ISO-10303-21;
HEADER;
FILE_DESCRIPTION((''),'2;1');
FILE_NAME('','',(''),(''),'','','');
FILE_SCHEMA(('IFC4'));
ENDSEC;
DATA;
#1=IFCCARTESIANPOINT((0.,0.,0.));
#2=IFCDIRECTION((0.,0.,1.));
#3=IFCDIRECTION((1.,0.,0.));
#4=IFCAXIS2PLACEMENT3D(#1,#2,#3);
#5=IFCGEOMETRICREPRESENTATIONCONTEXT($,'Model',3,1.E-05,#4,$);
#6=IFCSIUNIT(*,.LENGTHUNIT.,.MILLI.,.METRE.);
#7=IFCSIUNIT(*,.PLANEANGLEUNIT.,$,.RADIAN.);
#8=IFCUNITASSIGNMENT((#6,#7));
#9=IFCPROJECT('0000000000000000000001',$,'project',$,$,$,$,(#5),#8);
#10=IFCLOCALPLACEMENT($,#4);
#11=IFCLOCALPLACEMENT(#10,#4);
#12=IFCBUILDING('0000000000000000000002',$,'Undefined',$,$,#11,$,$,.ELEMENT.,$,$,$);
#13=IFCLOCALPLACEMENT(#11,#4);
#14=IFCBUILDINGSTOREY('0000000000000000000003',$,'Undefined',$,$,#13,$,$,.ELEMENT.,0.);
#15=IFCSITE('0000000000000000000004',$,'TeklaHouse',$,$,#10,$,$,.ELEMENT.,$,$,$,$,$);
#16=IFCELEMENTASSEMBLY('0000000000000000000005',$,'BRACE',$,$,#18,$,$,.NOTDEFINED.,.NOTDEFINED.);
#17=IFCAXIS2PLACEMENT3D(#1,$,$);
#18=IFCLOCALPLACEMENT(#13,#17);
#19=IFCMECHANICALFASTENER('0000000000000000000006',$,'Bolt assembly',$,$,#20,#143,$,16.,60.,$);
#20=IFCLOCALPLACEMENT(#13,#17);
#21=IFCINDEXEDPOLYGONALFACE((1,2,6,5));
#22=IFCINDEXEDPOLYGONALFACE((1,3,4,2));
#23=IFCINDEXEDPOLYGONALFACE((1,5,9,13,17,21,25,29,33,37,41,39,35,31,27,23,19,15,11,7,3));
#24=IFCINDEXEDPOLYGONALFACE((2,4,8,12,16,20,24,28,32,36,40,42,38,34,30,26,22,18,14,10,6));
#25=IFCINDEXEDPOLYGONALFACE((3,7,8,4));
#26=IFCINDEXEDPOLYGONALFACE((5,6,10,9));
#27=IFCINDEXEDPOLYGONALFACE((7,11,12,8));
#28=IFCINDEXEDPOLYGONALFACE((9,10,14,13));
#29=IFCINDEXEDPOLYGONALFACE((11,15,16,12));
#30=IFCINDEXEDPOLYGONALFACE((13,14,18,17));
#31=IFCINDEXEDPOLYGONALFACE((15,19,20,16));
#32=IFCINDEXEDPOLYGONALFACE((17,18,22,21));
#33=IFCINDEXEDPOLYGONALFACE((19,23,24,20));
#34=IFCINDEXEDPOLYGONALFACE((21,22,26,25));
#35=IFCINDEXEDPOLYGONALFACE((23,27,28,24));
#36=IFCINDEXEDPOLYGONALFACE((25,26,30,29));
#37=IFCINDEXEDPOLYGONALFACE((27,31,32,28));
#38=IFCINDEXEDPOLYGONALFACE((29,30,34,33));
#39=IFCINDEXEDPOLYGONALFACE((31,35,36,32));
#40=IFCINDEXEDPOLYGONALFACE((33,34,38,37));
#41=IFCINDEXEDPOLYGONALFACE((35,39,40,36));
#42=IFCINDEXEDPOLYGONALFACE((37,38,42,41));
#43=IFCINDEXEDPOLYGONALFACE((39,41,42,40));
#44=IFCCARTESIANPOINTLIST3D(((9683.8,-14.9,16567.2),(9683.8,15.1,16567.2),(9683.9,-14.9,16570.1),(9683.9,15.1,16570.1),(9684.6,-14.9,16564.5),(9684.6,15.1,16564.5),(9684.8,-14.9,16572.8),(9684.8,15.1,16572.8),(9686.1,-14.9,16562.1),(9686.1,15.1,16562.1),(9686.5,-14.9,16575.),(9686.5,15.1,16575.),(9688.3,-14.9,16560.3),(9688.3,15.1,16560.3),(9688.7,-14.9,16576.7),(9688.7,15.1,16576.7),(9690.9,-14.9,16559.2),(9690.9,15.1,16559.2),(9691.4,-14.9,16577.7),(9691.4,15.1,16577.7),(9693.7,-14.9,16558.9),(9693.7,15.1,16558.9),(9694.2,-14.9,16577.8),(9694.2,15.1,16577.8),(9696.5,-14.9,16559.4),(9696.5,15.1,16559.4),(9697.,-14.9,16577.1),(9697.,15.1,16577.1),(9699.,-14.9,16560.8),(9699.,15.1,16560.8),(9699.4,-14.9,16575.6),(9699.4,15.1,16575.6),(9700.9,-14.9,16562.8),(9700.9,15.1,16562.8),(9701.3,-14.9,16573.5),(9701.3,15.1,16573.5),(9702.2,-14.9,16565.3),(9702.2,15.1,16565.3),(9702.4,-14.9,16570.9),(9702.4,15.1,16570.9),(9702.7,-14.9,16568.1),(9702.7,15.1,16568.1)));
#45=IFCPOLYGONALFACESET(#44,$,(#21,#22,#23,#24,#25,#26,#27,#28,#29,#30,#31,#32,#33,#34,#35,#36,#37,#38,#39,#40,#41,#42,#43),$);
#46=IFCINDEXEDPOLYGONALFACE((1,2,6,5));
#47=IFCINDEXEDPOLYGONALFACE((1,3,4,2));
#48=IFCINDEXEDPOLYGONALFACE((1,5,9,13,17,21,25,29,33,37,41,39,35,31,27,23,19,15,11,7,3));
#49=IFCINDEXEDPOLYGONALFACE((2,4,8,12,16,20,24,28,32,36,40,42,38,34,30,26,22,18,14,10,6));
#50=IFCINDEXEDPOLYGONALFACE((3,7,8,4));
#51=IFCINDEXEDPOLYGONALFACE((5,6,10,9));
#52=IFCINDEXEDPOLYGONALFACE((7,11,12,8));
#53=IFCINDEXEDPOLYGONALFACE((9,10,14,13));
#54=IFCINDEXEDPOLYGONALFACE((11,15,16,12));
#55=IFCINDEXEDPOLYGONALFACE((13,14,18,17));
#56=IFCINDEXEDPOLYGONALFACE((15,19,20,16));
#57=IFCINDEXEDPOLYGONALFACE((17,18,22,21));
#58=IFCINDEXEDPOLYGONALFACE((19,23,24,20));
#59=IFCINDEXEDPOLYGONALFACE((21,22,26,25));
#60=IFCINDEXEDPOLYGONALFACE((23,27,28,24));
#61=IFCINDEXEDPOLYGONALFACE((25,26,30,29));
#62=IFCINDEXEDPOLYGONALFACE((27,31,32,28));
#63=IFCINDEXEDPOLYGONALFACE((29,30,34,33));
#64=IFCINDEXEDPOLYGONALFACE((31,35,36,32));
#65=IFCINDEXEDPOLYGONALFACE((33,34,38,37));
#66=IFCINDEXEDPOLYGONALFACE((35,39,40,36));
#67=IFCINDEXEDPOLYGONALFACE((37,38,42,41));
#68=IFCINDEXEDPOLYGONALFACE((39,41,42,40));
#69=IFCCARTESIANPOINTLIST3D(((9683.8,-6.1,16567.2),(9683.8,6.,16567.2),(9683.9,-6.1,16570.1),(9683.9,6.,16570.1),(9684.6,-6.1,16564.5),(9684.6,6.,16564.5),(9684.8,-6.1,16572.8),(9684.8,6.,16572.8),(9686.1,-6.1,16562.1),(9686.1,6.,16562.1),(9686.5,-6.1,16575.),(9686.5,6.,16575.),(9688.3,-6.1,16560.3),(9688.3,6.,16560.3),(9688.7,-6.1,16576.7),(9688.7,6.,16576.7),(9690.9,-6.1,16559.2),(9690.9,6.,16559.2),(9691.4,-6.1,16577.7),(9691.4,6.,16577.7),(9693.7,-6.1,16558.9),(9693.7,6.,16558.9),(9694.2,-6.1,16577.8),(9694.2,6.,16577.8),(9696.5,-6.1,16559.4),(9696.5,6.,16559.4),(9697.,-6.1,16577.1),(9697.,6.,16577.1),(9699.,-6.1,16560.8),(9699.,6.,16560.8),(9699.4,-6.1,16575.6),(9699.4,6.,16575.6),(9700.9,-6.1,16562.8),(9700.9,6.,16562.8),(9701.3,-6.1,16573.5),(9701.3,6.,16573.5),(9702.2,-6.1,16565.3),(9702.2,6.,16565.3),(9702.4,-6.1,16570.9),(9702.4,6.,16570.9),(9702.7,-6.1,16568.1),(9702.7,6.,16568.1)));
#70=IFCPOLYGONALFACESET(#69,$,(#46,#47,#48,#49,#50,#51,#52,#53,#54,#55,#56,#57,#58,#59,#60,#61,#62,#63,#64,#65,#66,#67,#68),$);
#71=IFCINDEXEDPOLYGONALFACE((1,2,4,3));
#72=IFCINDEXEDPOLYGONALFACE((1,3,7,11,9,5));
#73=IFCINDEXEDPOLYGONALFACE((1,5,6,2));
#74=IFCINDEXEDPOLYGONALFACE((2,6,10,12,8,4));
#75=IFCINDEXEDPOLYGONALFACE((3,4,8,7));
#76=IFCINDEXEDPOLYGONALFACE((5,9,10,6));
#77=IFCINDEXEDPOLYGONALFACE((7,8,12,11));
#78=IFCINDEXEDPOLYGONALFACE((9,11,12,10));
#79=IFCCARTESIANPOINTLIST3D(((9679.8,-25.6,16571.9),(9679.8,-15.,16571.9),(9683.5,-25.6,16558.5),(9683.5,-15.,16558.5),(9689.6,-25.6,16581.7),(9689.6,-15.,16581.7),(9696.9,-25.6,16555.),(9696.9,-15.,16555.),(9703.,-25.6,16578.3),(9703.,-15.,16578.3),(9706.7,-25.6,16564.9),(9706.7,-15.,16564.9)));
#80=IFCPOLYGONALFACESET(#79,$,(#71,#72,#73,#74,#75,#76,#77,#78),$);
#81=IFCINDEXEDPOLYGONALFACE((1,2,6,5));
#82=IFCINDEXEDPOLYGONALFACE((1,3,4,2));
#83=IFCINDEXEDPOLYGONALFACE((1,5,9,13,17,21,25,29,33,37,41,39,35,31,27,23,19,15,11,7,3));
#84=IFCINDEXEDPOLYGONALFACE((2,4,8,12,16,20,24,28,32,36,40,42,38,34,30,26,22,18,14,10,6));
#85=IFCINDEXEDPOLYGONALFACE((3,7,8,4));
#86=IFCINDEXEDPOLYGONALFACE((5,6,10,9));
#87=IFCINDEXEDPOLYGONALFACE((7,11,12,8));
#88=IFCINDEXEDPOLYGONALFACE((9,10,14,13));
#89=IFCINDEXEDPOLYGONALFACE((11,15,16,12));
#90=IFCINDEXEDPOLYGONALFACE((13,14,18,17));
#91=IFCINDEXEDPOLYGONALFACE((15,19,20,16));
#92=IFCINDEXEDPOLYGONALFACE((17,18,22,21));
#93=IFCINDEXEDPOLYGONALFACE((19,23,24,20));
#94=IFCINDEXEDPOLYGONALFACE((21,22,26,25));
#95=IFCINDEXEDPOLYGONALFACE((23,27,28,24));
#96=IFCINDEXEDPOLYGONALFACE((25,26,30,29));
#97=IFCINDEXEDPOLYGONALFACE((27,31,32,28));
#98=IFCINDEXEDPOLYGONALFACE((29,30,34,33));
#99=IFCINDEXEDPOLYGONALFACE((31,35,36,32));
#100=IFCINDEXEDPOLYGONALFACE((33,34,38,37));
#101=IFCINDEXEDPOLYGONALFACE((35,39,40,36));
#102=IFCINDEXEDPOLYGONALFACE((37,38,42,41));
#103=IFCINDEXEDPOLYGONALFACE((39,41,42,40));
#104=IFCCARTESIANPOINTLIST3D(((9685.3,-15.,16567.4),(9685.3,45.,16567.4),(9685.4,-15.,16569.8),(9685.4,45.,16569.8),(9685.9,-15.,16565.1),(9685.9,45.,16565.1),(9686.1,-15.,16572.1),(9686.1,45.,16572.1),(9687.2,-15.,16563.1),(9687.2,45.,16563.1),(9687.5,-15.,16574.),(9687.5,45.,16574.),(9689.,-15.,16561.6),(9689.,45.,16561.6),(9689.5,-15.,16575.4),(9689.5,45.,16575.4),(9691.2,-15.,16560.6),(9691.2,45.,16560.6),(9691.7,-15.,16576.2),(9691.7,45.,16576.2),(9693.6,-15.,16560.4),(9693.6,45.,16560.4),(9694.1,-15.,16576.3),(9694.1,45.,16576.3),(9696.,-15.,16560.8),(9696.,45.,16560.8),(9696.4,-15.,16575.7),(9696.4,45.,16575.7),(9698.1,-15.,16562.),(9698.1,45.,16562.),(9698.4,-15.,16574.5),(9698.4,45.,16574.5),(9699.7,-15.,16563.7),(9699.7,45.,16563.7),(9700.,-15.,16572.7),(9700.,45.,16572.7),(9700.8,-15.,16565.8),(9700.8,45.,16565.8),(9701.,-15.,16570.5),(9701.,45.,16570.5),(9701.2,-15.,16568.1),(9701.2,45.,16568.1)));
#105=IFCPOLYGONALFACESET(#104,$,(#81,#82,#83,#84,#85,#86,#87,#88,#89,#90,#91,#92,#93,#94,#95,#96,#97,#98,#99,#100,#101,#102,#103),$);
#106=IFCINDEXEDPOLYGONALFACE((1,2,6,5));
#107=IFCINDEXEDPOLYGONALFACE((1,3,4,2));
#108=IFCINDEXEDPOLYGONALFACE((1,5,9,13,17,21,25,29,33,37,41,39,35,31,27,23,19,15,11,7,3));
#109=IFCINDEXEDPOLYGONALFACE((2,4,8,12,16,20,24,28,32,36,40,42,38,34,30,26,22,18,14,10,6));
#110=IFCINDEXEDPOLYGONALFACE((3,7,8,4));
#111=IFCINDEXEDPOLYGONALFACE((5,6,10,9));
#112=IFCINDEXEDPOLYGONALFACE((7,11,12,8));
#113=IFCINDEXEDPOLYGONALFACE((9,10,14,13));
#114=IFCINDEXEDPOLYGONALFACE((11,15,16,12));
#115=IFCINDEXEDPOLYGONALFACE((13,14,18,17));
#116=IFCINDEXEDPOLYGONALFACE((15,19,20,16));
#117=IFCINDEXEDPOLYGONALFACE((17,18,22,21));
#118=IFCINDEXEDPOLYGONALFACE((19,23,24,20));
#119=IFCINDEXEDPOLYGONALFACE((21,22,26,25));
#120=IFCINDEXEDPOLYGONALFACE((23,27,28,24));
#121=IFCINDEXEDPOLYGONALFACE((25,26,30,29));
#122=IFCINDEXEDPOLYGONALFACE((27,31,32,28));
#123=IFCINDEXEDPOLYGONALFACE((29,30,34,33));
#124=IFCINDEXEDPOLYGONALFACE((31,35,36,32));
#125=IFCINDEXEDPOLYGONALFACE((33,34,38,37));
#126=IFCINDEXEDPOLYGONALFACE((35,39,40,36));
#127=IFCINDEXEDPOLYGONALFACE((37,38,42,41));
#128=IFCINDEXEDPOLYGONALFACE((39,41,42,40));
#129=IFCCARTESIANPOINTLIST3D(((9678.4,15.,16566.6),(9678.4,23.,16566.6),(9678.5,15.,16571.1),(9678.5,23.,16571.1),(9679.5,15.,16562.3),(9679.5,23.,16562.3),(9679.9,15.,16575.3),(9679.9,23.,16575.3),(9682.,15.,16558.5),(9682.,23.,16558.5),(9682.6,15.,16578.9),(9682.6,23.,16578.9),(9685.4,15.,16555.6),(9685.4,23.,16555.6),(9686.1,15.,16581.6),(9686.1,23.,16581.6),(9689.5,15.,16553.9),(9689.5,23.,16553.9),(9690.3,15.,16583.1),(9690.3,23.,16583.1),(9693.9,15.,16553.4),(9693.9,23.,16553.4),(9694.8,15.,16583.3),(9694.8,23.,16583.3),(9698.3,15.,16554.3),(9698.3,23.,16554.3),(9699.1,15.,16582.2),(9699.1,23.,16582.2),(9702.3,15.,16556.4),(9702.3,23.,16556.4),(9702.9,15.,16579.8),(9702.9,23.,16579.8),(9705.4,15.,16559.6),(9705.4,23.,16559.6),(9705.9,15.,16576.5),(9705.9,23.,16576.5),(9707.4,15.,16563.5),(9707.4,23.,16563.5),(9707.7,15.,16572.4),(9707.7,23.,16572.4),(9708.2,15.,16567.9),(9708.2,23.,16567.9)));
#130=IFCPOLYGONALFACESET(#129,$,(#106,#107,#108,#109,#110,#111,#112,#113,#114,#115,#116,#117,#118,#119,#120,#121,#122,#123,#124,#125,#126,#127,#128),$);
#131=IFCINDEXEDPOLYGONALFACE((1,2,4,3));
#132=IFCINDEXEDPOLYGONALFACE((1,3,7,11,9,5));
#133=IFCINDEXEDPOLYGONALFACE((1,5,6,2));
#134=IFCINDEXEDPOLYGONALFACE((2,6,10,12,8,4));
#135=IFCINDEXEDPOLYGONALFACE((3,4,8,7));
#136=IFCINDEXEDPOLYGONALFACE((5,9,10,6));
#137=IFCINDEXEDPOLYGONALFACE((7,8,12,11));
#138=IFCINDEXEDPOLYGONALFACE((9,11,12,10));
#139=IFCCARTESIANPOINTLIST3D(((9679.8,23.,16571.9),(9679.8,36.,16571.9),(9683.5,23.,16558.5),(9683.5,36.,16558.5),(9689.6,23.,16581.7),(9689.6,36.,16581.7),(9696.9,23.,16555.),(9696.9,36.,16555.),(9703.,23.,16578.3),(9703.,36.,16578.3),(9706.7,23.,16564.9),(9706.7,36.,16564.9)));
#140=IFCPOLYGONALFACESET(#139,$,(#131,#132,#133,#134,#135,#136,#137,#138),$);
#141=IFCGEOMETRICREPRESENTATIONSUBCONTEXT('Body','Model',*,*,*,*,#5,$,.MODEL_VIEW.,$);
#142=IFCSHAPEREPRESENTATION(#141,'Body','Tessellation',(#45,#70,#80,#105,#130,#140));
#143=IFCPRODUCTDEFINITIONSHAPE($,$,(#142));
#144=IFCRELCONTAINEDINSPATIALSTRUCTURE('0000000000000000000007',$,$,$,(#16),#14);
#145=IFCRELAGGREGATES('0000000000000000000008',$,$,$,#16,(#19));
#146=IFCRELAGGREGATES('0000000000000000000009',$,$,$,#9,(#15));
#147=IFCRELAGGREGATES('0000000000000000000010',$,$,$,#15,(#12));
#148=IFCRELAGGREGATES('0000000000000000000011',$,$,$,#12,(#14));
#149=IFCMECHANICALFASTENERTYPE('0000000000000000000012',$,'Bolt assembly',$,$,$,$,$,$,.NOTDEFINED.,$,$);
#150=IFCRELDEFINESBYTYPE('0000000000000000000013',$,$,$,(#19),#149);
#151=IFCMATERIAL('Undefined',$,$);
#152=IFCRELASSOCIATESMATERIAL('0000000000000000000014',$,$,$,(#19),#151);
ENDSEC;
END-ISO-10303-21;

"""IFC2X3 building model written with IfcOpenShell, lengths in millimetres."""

from ifc_helpers import new_model, si_unit, frame, origin_with_axes, origin_2d_with_axis, place, context, subcontext, project, spatial, polyline, circle, outline, extrude, source, transform, mapped, material, type_object, element, aggregate, save


model = new_model("IFC2X3")

# Units and contexts
model_context = context("Model", 3, precision=1e-05, world=origin_with_axes())
body_context = subcontext(model_context, "Body", "Model", "MODEL_VIEW")
ifc_project = project(units=[si_unit("LENGTHUNIT", "METRE", prefix="MILLI"), si_unit("PLANEANGLEUNIT", "RADIAN")], contexts=[model_context])

# Site, building, storey
site_placement = place(None, origin_with_axes())
site = spatial("IfcSite", under=ifc_project, at=site_placement, Name="TeklaHouse", CompositionType="ELEMENT")
building_placement = place(site_placement, origin_with_axes())
building = spatial("IfcBuilding", under=site, at=building_placement, Name="Undefined", CompositionType="ELEMENT")
storey_placement = place(building_placement, origin_with_axes())
storey = spatial("IfcBuildingStorey", under=building, at=storey_placement, Name="Undefined", CompositionType="ELEMENT", Elevation=0.0)

# Element assembly
assembly_1_placement = place(storey_placement, origin_with_axes())
assembly_1 = element("IfcElementAssembly", 1, at=assembly_1_placement, inside=storey, Name="BRACE", AssemblyPlace="NOTDEFINED", PredefinedType="NOTDEFINED")

# Shared definitions
ifc_material_1 = material(Name="Undefined")
mechanical_fastener_type = type_object("IfcMechanicalFastenerType", Name="Bolt assembly")

# Mechanical fastener
shared_shape_1 = source(origin_with_axes(), body_context, "Body", "SweptSolid", [
    extrude(circle(Radius=9.5, at=origin_2d_with_axis()), frame((0.0, -14.9, 0.0), z_axis=(0.0, 1.0, 0.0), x_axis=(1.0, 0.0, 0.0)), (0.0, 0.0, 1.0), 30.0),
    extrude(circle(Radius=9.5, at=origin_2d_with_axis()), frame((0.0, -6.1, 0.0), z_axis=(0.0, 1.0, 0.0), x_axis=(1.0, 0.0, 0.0)), (0.0, 0.0, 1.0), 12.1),
    extrude(outline(polyline([(12.0, -6.9), (12.0, 6.9), (0.0, 13.9), (-12.0, 6.9), (-12.0, -6.9), (0.0, -13.9), (12.0, -6.9)])), frame((0.0, -25.6, 0.0), z_axis=(0.0, 1.0, 0.0), x_axis=(1.0, 0.0, 0.0)), (0.0, 0.0, 1.0), 10.6),
    extrude(circle(Radius=8.0, at=origin_2d_with_axis()), frame((0.0, -15.0, 0.0), z_axis=(0.0, 1.0, 0.0), x_axis=(1.0, 0.0, 0.0)), (0.0, 0.0, 1.0), 60.0),
    extrude(circle(Radius=15.0, at=origin_2d_with_axis()), frame((0.0, 15.0, 0.0), z_axis=(0.0, 1.0, 0.0), x_axis=(1.0, 0.0, 0.0)), (0.0, 0.0, 1.0), 8.0),
    extrude(outline(polyline([(12.0, -6.9), (12.0, 6.9), (0.0, 13.9), (-12.0, 6.9), (-12.0, -6.9), (0.0, -13.9), (12.0, -6.9)])), frame((0.0, 23.0, 0.0), z_axis=(0.0, 1.0, 0.0), x_axis=(1.0, 0.0, 0.0)), (0.0, 0.0, 1.0), 13.0),
])
mechanical_fastener_1_placement = place(assembly_1_placement, frame((9693.2, 0.0, 16568.4), z_axis=(-0.701604, 0.0, -0.712567), x_axis=(-0.712567, 0.0, 0.701604)))
mechanical_fastener_1 = element("IfcMechanicalFastener", 2, at=mechanical_fastener_1_placement, type_object=mechanical_fastener_type, material=ifc_material_1, Name="Bolt assembly", NominalDiameter=16.0, NominalLength=60.0, context=body_context, shape_type="MappedRepresentation", body=[
    mapped(shared_shape_1, transform((0.0, 0.0, 0.0))),
])
aggregate(assembly_1, [mechanical_fastener_1])

save(model, "model.ifc")
